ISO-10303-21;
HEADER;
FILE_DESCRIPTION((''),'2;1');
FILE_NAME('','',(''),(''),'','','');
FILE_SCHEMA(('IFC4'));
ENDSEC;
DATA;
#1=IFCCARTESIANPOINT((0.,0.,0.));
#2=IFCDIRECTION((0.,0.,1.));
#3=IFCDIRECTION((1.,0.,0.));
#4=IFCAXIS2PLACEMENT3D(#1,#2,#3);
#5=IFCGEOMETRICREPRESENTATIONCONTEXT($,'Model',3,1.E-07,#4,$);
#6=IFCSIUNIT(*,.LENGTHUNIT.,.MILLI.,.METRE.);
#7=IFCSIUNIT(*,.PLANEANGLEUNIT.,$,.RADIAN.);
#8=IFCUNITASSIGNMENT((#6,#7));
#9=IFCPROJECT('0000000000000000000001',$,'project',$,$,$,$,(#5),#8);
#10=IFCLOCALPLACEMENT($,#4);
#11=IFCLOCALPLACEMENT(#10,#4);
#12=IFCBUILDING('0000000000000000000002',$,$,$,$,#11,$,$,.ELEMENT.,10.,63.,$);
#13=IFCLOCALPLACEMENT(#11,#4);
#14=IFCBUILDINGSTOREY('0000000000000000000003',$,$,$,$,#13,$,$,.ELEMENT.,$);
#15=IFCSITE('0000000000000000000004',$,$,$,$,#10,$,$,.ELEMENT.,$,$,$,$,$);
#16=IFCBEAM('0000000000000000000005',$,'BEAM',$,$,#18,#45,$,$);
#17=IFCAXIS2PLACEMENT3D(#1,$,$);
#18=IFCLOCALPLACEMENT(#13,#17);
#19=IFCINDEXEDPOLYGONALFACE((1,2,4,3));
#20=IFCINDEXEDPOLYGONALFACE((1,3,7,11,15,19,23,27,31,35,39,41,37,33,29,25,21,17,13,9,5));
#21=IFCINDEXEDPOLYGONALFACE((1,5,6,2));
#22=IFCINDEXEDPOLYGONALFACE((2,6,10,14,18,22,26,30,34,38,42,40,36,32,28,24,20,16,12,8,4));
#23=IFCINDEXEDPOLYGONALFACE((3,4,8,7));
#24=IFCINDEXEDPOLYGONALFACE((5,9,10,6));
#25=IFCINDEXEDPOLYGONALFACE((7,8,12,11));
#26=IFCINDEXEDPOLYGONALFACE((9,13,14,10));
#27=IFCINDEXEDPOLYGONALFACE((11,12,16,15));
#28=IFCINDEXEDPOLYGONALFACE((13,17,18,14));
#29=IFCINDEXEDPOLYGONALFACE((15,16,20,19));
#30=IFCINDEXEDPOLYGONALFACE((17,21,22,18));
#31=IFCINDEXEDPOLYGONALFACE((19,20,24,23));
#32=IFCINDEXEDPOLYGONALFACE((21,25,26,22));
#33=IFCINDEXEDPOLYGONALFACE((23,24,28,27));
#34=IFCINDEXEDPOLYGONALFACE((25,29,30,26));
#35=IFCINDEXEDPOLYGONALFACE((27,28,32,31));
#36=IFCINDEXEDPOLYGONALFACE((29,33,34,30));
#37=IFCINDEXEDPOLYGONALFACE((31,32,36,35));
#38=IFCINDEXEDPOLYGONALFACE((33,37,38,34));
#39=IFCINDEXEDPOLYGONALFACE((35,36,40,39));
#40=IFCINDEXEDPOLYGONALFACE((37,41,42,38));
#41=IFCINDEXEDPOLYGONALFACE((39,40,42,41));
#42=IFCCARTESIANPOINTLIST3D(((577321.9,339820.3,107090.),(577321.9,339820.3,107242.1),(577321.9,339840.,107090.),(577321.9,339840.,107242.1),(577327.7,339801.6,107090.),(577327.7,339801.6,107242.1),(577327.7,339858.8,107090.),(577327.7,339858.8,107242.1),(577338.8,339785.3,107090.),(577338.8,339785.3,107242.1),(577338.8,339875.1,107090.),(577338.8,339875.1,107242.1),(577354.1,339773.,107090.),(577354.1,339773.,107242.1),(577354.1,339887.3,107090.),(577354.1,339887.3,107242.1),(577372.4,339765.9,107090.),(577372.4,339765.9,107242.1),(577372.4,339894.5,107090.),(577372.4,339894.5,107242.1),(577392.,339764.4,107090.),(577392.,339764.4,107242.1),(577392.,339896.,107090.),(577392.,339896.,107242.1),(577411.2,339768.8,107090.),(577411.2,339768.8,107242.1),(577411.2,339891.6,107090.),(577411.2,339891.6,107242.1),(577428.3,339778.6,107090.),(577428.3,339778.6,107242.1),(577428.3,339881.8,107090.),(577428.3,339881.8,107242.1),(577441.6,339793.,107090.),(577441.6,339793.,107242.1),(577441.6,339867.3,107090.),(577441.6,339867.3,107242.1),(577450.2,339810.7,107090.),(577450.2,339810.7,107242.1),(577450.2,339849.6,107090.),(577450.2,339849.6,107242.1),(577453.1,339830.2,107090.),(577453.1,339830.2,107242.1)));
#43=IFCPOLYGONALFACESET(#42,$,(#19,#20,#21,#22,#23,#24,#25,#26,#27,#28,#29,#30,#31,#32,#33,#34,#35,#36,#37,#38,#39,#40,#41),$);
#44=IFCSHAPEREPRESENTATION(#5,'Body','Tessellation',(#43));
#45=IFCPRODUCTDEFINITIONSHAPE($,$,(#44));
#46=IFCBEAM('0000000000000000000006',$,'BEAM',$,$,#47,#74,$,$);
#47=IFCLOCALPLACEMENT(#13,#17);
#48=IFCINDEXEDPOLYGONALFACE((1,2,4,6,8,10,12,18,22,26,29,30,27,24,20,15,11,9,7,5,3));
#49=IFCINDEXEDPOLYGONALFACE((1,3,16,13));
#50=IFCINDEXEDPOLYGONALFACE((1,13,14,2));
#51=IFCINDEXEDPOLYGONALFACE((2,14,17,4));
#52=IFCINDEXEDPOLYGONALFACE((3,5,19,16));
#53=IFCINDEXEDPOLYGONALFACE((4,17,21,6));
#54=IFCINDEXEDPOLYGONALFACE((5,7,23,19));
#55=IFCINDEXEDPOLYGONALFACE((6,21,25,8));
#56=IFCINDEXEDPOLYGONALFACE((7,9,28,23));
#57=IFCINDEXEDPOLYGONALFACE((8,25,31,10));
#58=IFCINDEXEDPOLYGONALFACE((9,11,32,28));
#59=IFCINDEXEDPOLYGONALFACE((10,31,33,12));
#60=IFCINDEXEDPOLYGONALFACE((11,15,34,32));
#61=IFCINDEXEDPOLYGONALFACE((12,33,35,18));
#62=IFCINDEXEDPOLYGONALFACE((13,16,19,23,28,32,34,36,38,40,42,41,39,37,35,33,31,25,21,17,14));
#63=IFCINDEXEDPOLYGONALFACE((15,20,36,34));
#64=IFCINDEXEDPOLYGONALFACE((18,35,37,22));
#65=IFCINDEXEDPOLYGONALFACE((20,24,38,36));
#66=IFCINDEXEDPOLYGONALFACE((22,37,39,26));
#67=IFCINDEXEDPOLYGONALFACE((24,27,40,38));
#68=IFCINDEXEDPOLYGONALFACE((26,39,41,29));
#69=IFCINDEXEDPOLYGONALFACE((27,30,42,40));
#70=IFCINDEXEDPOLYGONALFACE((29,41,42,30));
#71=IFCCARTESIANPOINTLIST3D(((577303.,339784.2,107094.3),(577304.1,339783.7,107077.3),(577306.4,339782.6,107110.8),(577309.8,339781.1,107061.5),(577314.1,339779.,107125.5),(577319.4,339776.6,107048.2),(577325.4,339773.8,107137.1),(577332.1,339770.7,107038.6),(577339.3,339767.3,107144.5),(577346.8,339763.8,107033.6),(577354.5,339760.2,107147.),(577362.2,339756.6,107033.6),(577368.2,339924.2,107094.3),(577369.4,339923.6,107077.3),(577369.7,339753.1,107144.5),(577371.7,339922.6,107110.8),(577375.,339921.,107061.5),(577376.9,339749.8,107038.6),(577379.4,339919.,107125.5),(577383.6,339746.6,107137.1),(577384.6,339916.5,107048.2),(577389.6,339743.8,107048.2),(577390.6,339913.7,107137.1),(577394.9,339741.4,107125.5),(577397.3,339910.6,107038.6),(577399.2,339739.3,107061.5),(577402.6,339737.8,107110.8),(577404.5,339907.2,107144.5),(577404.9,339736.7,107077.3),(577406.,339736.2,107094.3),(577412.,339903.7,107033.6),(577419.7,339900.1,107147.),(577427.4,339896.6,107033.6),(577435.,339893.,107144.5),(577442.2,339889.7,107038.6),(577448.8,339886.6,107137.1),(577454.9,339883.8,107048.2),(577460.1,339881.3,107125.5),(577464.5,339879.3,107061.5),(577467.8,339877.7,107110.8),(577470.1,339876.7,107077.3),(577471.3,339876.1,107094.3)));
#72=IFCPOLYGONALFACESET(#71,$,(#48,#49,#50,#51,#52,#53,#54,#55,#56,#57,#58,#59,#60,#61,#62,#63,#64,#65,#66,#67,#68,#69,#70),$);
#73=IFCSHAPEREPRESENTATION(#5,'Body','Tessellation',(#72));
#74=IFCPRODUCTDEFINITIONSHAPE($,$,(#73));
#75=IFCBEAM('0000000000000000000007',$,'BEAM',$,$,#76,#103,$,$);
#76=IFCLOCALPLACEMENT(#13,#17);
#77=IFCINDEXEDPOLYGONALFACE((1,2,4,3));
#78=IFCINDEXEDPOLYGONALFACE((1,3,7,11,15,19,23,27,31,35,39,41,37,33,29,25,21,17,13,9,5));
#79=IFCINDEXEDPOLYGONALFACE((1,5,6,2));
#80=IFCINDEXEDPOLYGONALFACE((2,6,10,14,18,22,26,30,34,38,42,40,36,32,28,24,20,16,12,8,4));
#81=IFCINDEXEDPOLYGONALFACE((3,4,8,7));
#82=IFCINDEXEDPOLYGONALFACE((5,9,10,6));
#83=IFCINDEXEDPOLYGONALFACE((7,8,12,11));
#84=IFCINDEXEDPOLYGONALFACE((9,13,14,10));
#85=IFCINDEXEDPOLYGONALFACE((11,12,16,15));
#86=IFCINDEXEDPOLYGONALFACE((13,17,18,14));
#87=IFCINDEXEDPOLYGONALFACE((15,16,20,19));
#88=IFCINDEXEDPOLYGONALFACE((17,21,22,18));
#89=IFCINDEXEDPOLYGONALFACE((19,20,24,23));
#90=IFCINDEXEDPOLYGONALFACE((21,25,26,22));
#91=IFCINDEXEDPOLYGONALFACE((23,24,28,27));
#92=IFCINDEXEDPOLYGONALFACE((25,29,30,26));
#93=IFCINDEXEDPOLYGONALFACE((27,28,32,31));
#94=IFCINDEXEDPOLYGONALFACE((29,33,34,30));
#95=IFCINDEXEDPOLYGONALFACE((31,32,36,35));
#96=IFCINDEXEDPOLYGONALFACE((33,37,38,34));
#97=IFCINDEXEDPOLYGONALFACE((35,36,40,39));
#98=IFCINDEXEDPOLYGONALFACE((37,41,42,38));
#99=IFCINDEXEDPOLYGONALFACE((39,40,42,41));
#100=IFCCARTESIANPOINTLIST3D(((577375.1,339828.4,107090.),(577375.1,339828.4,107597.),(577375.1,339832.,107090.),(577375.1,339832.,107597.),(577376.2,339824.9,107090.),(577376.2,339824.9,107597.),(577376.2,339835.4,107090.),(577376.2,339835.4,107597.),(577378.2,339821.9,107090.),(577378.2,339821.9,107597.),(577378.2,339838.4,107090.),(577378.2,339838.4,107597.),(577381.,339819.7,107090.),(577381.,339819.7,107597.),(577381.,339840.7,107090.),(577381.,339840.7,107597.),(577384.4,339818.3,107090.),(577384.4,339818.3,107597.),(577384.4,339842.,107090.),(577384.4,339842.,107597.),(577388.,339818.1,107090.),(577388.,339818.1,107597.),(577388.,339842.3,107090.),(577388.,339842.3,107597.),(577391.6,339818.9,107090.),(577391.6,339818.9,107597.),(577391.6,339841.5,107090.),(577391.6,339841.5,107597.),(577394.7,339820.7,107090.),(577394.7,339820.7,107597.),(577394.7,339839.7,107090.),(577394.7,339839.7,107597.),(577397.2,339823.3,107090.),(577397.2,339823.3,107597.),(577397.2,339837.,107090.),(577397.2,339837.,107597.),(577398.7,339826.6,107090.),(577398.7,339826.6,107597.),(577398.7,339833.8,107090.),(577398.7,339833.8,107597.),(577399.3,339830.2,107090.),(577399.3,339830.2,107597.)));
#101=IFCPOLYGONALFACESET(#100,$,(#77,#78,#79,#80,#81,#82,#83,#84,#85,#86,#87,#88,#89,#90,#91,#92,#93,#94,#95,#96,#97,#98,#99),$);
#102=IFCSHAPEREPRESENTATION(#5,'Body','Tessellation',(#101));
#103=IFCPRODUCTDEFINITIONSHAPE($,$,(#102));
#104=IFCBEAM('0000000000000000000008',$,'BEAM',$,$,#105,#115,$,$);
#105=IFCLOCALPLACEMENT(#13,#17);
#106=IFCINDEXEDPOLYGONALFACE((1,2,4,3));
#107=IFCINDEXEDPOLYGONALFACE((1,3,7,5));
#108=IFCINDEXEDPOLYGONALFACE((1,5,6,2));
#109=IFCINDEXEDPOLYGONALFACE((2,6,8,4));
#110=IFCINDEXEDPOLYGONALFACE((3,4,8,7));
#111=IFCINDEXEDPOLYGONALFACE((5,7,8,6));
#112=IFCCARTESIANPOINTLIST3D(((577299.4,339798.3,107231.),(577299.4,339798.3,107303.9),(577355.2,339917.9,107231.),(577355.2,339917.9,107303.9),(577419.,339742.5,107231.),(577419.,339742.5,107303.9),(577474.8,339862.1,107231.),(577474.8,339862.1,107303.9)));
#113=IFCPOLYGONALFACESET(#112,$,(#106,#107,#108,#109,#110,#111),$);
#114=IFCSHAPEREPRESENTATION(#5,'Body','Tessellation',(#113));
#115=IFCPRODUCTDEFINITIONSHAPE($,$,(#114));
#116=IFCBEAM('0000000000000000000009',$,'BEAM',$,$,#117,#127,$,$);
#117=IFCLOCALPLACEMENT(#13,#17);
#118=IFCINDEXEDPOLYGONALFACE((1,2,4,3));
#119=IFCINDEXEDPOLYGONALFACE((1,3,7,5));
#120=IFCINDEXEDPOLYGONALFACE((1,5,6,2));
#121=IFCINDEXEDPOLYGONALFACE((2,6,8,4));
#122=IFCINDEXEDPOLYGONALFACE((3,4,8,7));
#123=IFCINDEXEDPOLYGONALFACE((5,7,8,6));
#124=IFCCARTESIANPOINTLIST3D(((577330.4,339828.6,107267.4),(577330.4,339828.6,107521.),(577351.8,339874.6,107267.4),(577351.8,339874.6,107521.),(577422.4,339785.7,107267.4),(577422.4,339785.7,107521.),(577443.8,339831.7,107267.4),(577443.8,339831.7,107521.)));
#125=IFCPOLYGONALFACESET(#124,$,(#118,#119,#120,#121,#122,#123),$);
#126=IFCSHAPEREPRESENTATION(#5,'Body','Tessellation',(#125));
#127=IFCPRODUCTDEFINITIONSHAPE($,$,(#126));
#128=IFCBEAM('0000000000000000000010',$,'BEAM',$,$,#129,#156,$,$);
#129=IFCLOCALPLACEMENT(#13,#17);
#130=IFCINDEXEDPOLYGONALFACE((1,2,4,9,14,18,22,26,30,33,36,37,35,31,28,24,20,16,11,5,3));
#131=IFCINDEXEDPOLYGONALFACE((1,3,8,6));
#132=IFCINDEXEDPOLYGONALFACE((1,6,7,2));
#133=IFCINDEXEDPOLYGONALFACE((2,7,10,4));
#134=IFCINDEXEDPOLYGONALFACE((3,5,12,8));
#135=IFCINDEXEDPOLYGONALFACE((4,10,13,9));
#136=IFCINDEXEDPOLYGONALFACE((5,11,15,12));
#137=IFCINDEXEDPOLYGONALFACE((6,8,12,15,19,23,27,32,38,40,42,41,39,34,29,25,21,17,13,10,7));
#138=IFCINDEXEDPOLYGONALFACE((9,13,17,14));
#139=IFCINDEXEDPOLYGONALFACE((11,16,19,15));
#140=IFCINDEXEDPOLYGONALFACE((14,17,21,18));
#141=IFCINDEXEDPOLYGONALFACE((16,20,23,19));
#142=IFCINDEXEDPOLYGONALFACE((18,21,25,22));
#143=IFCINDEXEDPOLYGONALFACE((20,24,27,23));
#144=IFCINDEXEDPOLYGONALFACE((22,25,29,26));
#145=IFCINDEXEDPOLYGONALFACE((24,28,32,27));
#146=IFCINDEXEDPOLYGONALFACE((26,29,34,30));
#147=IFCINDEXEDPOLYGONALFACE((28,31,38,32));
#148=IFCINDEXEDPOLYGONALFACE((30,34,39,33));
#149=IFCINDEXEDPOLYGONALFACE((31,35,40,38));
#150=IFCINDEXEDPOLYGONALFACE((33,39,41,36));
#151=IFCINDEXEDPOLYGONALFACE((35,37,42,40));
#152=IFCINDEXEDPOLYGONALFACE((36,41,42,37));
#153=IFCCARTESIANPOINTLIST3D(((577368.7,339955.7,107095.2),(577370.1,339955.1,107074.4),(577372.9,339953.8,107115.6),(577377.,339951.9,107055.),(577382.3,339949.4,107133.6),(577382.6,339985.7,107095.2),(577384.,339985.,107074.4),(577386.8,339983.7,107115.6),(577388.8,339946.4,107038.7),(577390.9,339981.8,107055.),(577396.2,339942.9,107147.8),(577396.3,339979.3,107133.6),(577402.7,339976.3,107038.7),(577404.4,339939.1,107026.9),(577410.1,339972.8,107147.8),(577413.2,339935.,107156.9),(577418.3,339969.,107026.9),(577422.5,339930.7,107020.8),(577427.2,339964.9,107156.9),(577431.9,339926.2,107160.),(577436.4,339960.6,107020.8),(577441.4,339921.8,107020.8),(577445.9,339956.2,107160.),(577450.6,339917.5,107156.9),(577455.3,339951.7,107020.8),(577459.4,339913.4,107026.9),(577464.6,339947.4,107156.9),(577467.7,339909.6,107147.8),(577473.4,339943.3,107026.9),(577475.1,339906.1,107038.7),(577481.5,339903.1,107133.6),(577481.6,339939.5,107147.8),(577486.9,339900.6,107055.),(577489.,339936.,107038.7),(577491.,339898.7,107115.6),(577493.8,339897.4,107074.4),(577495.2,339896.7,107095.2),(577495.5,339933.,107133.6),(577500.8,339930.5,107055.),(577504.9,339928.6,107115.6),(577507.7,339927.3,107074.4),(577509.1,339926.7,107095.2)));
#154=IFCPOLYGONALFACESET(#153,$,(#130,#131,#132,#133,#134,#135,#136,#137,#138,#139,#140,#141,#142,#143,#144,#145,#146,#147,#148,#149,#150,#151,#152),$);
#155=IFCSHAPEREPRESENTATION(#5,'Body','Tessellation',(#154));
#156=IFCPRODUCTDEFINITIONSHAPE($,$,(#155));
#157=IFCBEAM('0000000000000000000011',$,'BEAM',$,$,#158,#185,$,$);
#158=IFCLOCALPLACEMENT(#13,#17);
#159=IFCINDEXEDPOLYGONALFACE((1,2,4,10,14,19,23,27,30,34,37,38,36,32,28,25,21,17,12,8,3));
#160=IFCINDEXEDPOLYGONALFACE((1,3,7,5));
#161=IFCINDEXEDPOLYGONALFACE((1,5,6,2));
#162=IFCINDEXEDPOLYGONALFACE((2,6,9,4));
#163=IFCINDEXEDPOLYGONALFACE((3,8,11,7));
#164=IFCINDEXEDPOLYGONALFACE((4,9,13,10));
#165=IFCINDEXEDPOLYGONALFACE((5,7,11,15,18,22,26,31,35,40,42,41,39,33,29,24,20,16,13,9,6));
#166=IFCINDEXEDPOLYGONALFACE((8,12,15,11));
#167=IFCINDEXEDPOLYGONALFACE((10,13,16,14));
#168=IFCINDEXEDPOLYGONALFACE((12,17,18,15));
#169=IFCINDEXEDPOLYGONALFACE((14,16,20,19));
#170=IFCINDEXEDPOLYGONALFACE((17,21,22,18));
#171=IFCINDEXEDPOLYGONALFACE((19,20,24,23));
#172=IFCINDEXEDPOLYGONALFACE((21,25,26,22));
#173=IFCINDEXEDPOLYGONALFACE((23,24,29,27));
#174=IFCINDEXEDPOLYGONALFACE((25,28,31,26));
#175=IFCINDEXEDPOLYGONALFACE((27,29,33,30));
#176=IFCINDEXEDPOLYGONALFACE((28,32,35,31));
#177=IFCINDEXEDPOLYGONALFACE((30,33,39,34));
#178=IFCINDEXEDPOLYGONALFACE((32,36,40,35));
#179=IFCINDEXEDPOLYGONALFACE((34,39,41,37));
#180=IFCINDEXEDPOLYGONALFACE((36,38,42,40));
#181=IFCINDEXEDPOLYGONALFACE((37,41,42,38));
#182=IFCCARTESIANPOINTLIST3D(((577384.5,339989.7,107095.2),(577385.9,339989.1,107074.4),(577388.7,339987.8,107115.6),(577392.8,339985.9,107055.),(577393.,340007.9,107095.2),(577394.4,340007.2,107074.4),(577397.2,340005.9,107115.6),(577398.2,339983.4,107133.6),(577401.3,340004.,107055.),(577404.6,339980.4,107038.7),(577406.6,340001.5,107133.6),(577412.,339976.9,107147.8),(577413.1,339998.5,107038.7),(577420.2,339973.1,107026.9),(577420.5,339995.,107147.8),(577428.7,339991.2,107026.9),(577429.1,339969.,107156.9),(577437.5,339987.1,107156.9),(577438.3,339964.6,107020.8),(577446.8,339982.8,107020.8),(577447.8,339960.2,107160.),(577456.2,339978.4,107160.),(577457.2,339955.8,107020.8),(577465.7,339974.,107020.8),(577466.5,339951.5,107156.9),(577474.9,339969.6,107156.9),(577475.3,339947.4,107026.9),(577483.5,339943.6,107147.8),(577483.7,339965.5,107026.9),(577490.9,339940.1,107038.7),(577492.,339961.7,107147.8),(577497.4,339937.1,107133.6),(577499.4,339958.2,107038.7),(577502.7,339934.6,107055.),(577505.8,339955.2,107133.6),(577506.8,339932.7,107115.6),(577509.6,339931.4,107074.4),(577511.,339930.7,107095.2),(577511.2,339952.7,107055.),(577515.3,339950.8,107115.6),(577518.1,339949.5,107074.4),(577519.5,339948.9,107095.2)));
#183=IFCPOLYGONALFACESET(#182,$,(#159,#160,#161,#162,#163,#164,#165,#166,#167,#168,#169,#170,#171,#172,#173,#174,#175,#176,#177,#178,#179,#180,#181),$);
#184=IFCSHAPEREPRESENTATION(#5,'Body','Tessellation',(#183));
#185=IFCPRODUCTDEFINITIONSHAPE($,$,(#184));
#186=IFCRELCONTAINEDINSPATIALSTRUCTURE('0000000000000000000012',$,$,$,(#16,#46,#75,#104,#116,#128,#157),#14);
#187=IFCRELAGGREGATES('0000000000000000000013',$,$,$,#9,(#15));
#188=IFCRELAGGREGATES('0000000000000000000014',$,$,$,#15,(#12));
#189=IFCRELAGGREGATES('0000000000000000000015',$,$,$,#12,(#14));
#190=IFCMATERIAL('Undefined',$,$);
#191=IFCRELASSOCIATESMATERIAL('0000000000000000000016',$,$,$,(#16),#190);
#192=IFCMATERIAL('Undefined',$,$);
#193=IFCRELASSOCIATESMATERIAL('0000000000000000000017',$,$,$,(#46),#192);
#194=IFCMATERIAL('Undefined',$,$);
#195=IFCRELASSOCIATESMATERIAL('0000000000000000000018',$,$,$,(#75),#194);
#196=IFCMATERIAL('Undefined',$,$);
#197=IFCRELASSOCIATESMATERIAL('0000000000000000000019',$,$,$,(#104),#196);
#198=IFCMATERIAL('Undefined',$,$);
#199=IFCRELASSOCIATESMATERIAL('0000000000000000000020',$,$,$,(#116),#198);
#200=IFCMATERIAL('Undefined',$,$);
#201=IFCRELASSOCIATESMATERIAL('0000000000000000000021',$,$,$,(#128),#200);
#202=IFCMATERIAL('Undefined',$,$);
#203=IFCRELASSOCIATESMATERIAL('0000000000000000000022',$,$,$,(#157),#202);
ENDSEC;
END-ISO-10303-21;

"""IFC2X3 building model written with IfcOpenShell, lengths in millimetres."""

from ifc_helpers import new_model, si_unit, frame, origin_with_axes, origin_2d_with_axis, place, context, project, spatial, rectangle, circle, extrude, material, element, save


model = new_model("IFC2X3")

# Units and contexts
model_context = context("Model", 3, precision=1e-07, world=origin_with_axes())
ifc_project = project(units=[si_unit("LENGTHUNIT", "METRE", prefix="MILLI"), si_unit("PLANEANGLEUNIT", "RADIAN")], contexts=[model_context])

# Site, building, storey
site_placement = place(None, origin_with_axes())
site = spatial("IfcSite", under=ifc_project, at=site_placement, CompositionType="ELEMENT")
building_placement = place(site_placement, origin_with_axes())
building = spatial("IfcBuilding", under=site, at=building_placement, CompositionType="ELEMENT", ElevationOfRefHeight=10.0, ElevationOfTerrain=63.0)
storey_placement = place(building_placement, origin_with_axes())
storey = spatial("IfcBuildingStorey", under=building, at=storey_placement, CompositionType="ELEMENT")

# Beams
ifc_material_1 = material(Name="Undefined")
beam_1_placement = place(storey_placement, frame((577387.1, 339830.2, 107166.1), z_axis=(0.0, 0.0, 1.0), x_axis=(0.0, 1.0, 0.0)))
element("IfcBeam", 1, at=beam_1_placement, inside=storey, material=ifc_material_1, Name="BEAM", context=model_context, shape_type="SweptSolid", body=[
    extrude(circle(Radius=66.0, at=origin_2d_with_axis()), frame((0.0, 0.0, -76.0), z_axis=(0.0, 0.0, 1.0), x_axis=(0.0, -1.0, 0.0)), (0.0, 0.0, 1.0), 152.1),
])
ifc_material_2 = material(Name="Undefined")
beam_2_placement = place(storey_placement, frame((577387.1, 339830.2, 107090.0), z_axis=(-0.422618, -0.906308, 0.0), x_axis=(-0.906308, 0.422618, 0.0)))
element("IfcBeam", 2, at=beam_2_placement, inside=storey, material=ifc_material_2, Name="BEAM", context=model_context, shape_type="SweptSolid", body=[
    extrude(circle(Radius=57.0, at=origin_2d_with_axis()), frame((0.0, 0.0, -77.2), z_axis=(0.0, 0.0, 1.0), x_axis=(0.0, -1.0, 0.0)), (0.0, 0.0, 1.0), 154.4),
])
ifc_material_3 = material(Name="Undefined")
beam_3_placement = place(storey_placement, frame((577387.1, 339830.2, 107343.5), z_axis=(0.0, 0.0, 1.0), x_axis=(0.0, 1.0, 0.0)))
element("IfcBeam", 3, at=beam_3_placement, inside=storey, material=ifc_material_3, Name="BEAM", context=model_context, shape_type="SweptSolid", body=[
    extrude(circle(Radius=12.2, at=origin_2d_with_axis()), frame((0.0, 0.0, -253.5), z_axis=(0.0, 0.0, 1.0), x_axis=(0.0, -1.0, 0.0)), (0.0, 0.0, 1.0), 507.0),
])
ifc_material_4 = material(Name="Undefined")
beam_4_placement = place(storey_placement, frame((577387.1, 339830.2, 107267.4), z_axis=(0.0, 0.0, 1.0), x_axis=(-0.906308, 0.422618, 0.0)))
element("IfcBeam", 4, at=beam_4_placement, inside=storey, material=ifc_material_4, Name="BEAM", context=model_context, shape_type="SweptSolid", body=[
    extrude(rectangle(XDim=131.9, YDim=131.9, at=origin_2d_with_axis()), frame((0.0, 0.0, -36.5), z_axis=(0.0, 0.0, 1.0), x_axis=(0.0, -1.0, 0.0)), (0.0, 0.0, 1.0), 72.9),
])
ifc_material_5 = material(Name="Undefined")
beam_5_placement = place(storey_placement, frame((577387.1, 339830.2, 107394.2), z_axis=(0.0, 0.0, 1.0), x_axis=(-0.906308, 0.422618, 0.0)))
element("IfcBeam", 5, at=beam_5_placement, inside=storey, material=ifc_material_5, Name="BEAM", context=model_context, shape_type="SweptSolid", body=[
    extrude(rectangle(XDim=50.8, YDim=101.5, at=origin_2d_with_axis()), frame((0.0, 0.0, -126.8), z_axis=(0.0, 0.0, 1.0), x_axis=(0.0, -1.0, 0.0)), (0.0, 0.0, 1.0), 253.5),
])
ifc_material_6 = material(Name="Undefined")
beam_6_placement = place(storey_placement, frame((577438.9, 339941.2, 107090.0), z_axis=(-0.422618, -0.906308, 0.0), x_axis=(-0.906308, 0.422618, 0.0)))
element("IfcBeam", 6, at=beam_6_placement, inside=storey, material=ifc_material_6, Name="BEAM", context=model_context, shape_type="SweptSolid", body=[
    extrude(circle(Radius=70.0, at=origin_2d_with_axis()), frame((0.0, 0.0, -16.5), z_axis=(0.0, 0.0, 1.0), x_axis=(0.0, -1.0, 0.0)), (0.0, 0.0, 1.0), 33.0),
])
ifc_material_7 = material(Name="Undefined")
beam_7_placement = place(storey_placement, frame((577452.0, 339969.3, 107090.0), z_axis=(-0.422618, -0.906308, 0.0), x_axis=(-0.906308, 0.422618, 0.0)))
element("IfcBeam", 7, at=beam_7_placement, inside=storey, material=ifc_material_7, Name="BEAM", context=model_context, shape_type="SweptSolid", body=[
    extrude(circle(Radius=70.0, at=origin_2d_with_axis()), frame((0.0, 0.0, -10.0), z_axis=(0.0, 0.0, 1.0), x_axis=(0.0, -1.0, 0.0)), (0.0, 0.0, 1.0), 20.0),
])

save(model, "model.ifc")
